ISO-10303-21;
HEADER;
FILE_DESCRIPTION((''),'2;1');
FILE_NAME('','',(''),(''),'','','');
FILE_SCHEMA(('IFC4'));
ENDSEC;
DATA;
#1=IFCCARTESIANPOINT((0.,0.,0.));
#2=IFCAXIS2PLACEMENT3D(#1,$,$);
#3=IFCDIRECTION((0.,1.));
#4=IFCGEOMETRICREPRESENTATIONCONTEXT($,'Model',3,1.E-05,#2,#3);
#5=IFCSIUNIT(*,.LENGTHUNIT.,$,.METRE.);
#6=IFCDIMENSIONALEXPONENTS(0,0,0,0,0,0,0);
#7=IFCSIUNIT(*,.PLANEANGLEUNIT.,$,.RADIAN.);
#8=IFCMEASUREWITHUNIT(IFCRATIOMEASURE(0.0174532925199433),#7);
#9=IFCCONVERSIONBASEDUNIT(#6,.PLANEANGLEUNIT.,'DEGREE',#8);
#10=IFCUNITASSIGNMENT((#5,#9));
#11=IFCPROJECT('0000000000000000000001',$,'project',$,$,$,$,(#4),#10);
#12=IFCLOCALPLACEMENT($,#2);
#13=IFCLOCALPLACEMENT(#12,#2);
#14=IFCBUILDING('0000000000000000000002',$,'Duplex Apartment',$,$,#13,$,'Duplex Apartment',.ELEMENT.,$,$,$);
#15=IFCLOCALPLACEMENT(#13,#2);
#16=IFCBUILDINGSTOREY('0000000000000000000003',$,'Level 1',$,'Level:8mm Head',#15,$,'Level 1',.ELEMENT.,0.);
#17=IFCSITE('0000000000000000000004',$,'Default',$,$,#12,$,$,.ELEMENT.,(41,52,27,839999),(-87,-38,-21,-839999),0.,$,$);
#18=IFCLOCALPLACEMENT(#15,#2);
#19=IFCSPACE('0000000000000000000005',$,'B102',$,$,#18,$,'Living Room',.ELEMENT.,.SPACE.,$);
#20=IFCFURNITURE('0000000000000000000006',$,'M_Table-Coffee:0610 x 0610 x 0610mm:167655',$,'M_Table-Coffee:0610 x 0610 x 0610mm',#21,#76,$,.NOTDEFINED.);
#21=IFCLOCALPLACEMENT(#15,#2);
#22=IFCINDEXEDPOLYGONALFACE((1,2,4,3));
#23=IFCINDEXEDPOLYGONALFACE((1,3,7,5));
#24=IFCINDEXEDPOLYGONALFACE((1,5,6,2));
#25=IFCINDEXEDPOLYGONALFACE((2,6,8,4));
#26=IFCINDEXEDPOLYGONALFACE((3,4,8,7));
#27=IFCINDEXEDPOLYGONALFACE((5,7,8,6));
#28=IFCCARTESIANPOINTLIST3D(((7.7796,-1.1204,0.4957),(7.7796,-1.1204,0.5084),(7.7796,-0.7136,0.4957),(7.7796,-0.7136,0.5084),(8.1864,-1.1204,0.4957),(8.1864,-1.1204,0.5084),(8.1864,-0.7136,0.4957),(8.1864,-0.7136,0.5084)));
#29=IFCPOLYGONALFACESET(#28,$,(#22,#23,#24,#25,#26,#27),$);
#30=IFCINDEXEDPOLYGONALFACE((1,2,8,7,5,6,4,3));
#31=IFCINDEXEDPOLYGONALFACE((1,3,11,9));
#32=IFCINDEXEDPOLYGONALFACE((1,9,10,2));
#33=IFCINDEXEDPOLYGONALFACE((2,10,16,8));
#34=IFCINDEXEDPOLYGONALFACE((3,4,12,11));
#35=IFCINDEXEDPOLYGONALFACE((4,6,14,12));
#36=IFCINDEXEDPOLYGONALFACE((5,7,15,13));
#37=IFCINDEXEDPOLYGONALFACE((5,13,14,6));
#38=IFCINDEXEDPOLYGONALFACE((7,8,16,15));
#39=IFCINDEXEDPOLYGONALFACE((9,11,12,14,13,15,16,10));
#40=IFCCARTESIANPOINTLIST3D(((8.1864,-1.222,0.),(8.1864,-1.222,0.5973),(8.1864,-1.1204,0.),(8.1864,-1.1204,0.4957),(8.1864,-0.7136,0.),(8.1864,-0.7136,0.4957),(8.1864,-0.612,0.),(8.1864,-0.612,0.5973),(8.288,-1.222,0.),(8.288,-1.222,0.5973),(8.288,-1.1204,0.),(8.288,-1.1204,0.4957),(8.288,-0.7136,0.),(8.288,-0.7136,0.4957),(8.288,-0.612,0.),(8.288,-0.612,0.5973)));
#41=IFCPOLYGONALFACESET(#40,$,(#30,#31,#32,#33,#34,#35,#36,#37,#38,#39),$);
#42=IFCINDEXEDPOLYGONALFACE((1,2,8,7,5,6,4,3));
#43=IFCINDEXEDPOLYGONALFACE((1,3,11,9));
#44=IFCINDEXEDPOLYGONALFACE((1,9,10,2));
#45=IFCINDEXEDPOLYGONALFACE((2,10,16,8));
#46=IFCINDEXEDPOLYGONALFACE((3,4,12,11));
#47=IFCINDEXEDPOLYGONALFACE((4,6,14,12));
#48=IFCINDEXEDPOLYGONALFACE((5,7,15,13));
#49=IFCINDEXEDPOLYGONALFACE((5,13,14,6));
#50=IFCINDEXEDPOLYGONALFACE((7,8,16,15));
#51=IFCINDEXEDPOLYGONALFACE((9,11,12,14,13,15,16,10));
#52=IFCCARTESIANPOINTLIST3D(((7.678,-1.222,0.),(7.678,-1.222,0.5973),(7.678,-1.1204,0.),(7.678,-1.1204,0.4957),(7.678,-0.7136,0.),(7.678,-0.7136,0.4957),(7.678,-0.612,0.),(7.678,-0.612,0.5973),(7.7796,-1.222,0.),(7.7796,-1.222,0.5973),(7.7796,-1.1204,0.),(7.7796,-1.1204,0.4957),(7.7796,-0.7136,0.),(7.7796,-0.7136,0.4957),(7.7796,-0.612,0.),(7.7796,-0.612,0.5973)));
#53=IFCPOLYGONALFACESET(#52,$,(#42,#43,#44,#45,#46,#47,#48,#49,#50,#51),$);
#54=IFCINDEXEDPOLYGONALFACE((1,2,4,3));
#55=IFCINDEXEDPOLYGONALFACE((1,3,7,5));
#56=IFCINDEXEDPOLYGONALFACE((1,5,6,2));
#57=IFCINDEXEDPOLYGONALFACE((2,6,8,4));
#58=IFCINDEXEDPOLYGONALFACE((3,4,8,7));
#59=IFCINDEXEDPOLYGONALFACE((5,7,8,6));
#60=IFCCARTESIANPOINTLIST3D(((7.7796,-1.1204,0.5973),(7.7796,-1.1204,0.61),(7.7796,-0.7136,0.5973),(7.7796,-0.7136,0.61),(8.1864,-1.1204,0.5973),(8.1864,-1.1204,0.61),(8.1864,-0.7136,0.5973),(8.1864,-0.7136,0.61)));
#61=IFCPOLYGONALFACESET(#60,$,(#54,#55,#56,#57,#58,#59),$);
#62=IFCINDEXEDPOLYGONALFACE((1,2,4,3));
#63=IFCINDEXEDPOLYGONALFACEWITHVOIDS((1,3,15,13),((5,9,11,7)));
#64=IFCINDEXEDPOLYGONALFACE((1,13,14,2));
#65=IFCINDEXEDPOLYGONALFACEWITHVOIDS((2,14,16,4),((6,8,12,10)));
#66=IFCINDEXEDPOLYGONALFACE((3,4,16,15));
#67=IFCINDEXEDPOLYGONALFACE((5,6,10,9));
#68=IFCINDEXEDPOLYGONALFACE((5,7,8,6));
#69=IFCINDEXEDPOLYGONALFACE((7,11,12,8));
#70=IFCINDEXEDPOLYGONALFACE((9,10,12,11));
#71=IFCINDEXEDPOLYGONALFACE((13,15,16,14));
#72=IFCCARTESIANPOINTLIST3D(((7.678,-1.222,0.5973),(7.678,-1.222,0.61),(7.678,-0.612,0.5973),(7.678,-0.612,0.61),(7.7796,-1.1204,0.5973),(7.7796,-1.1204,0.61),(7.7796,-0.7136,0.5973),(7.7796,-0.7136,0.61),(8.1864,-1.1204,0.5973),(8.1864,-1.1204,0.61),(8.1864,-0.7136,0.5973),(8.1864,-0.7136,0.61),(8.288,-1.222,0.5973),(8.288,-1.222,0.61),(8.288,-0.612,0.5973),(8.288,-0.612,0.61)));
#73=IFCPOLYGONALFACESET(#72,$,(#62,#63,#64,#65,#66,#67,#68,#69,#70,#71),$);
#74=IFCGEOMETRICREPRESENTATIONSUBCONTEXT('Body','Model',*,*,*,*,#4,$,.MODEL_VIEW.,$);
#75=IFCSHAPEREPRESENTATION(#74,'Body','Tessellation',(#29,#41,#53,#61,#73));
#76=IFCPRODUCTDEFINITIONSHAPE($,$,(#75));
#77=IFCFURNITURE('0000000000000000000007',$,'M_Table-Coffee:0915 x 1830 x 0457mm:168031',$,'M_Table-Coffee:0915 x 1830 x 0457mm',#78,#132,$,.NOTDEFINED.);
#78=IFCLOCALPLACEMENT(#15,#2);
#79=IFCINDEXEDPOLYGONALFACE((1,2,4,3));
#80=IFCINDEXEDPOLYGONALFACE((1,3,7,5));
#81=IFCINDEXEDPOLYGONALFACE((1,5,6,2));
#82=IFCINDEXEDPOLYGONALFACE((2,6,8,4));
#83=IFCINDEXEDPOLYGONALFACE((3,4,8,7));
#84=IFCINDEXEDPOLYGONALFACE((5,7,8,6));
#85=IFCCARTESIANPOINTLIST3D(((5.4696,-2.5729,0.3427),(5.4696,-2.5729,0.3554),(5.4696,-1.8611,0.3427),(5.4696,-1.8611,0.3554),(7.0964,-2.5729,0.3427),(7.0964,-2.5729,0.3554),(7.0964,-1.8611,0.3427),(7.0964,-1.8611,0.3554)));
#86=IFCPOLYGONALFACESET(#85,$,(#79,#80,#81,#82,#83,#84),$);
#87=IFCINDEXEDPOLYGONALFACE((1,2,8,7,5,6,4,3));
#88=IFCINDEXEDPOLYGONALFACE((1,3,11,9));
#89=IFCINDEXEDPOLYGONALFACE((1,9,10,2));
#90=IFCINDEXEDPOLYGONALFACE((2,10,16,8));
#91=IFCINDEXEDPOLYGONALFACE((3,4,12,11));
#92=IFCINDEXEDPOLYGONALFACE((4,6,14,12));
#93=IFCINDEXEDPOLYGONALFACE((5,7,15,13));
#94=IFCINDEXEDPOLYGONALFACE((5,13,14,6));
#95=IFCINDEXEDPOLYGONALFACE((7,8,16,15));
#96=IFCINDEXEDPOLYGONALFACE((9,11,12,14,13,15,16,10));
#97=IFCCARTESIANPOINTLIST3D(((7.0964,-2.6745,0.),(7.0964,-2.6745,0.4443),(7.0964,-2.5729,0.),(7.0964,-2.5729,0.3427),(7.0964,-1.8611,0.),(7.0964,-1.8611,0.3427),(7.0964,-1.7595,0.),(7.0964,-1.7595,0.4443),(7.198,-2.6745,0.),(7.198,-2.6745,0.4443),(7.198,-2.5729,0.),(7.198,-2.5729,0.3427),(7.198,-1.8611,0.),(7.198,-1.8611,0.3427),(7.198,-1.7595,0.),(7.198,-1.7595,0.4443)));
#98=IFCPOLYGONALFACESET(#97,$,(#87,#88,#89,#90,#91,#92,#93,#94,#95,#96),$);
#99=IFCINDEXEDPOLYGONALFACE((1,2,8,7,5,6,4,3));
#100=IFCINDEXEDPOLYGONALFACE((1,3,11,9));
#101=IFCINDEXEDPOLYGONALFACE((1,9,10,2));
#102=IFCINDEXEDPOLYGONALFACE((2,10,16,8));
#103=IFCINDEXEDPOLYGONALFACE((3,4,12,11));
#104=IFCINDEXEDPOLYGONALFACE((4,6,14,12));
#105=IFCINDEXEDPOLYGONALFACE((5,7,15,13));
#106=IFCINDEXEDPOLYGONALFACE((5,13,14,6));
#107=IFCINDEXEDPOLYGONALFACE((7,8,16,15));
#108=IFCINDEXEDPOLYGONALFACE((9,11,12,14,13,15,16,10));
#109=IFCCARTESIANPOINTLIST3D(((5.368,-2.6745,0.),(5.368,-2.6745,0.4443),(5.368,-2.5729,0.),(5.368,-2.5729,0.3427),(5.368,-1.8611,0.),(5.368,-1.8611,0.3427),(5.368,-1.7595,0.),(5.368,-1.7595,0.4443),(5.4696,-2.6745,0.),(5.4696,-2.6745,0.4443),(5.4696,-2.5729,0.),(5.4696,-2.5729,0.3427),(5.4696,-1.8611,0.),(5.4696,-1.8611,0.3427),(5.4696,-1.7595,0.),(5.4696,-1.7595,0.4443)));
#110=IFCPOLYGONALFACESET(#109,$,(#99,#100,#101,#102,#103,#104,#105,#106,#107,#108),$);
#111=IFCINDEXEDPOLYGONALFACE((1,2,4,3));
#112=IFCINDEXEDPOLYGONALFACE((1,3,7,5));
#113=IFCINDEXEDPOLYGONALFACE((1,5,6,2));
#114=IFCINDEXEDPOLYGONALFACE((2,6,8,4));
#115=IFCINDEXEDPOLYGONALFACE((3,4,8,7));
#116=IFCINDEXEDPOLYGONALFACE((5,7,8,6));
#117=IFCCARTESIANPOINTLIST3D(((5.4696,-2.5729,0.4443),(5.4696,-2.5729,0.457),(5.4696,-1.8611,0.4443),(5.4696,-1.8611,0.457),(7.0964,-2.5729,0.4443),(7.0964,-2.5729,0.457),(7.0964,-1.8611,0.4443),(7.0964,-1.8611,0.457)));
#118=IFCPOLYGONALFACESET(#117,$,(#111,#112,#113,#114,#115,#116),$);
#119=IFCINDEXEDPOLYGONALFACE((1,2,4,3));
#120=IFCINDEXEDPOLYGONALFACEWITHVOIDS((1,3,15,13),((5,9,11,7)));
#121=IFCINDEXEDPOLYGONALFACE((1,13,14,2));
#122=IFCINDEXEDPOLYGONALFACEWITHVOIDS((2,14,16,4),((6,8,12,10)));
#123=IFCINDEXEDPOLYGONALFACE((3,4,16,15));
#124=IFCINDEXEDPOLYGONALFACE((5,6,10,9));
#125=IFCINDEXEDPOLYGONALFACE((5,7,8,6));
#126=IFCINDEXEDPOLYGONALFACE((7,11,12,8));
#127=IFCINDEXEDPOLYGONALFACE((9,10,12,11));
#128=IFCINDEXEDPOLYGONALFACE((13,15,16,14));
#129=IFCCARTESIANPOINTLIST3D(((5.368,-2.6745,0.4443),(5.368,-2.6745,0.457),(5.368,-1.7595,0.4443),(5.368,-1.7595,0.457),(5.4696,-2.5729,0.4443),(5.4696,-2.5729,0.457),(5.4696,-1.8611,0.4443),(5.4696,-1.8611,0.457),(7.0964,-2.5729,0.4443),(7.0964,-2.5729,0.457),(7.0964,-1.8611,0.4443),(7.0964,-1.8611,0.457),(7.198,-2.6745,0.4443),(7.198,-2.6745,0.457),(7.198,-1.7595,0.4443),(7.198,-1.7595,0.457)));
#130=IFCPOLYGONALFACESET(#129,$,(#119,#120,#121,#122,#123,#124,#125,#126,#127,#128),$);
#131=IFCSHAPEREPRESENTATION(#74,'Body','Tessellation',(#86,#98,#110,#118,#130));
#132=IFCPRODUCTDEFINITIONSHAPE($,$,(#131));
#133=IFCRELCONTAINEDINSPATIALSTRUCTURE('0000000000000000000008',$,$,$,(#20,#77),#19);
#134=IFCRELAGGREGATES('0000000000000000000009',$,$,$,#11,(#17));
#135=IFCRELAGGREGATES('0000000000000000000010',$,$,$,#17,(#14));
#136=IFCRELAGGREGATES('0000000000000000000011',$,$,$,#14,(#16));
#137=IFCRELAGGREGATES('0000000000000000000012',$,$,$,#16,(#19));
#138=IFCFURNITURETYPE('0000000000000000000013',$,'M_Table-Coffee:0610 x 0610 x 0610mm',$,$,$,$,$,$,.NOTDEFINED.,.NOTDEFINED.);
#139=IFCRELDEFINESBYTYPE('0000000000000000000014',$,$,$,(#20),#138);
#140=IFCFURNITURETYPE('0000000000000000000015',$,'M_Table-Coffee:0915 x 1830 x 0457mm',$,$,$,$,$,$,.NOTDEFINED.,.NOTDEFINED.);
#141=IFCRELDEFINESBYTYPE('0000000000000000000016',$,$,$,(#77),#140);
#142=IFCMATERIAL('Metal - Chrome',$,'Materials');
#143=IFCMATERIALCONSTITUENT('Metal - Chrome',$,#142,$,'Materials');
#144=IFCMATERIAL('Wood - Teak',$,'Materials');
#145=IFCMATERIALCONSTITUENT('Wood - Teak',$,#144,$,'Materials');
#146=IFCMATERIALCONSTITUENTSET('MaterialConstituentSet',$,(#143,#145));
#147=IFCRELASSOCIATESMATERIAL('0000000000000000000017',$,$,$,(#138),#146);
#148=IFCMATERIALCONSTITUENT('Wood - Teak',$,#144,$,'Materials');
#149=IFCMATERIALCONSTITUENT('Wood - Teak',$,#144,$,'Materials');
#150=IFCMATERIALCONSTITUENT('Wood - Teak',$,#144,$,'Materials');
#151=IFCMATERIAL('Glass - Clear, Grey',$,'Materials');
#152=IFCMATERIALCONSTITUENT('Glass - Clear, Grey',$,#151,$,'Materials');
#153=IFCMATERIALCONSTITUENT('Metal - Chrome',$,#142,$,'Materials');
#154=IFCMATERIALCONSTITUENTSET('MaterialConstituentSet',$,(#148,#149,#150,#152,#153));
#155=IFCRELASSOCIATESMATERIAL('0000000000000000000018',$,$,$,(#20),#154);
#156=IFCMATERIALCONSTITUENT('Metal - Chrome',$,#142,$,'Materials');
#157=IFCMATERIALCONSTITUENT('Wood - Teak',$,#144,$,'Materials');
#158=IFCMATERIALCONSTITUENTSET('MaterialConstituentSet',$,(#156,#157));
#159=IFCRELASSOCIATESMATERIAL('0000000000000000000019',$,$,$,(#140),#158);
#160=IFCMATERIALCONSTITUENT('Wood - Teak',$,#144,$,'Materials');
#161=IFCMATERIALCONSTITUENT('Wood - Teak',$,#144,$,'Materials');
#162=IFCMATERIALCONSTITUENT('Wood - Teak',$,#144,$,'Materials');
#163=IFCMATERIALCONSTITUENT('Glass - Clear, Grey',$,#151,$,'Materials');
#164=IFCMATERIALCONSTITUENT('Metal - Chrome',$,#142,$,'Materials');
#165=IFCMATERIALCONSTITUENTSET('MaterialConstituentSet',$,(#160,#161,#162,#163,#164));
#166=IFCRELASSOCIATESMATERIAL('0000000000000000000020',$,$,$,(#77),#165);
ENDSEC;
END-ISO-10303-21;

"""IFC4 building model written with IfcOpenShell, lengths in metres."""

from ifc_helpers import new_model, entity, si_unit, converted_unit, direction, frame, origin, place, context, subcontext, project, spatial, indexed_curve, outline, extrude, source, transform, mapped, material, constituent, constituent_set, type_object, type_shapes, element, save


model = new_model("IFC4")

# Units and contexts
model_context = context("Model", 3, precision=1e-05, world=origin(), true_north=direction((0.0, 1.0)))
body_context = subcontext(model_context, "Body", "Model", "MODEL_VIEW")
ifc_project = project(units=[si_unit("LENGTHUNIT", "METRE"), converted_unit("PLANEANGLEUNIT", "DEGREE", entity("IfcRatioMeasure", 0.0174532925199433), si_unit("PLANEANGLEUNIT", "RADIAN"), dimensions=[0, 0, 0, 0, 0, 0, 0])], contexts=[model_context])

# Site, building, storey
site_placement = place(None, origin())
site = spatial("IfcSite", under=ifc_project, at=site_placement, Name="Default", CompositionType="ELEMENT", RefLatitude=(41, 52, 27, 839999), RefLongitude=(-87, -38, -21, -839999), RefElevation=0.0)
building_placement = place(site_placement, origin())
building = spatial("IfcBuilding", under=site, at=building_placement, Name="Duplex Apartment", LongName="Duplex Apartment", CompositionType="ELEMENT")
storey_placement = place(building_placement, origin())
storey = spatial("IfcBuildingStorey", under=building, at=storey_placement, Name="Level 1", ObjectType="Level:8mm Head", LongName="Level 1", CompositionType="ELEMENT", Elevation=0.0)

# Shared definitions
space_1_placement = place(storey_placement, origin())
space_1 = spatial("IfcSpace", under=storey, at=space_1_placement, Name="B102", LongName="Living Room", CompositionType="ELEMENT", PredefinedType="SPACE")

# Furniture
ifc_material_1 = material(Name="Wood - Teak", Category="Materials")
ifc_constituent_1 = constituent(ifc_material_1, Name="Wood - Teak", Category="Materials")
ifc_constituent_2 = constituent(ifc_material_1, Name="Wood - Teak", Category="Materials")
ifc_constituent_3 = constituent(ifc_material_1, Name="Wood - Teak", Category="Materials")
ifc_material_2 = material(Name="Glass - Clear, Grey", Category="Materials")
ifc_constituent_4 = constituent(ifc_material_2, Name="Glass - Clear, Grey", Category="Materials")
ifc_material_3 = material(Name="Metal - Chrome", Category="Materials")
ifc_constituent_5 = constituent(ifc_material_3, Name="Metal - Chrome", Category="Materials")
ifc_constituent_set_1 = constituent_set(constituents=[ifc_constituent_1, ifc_constituent_2, ifc_constituent_3, ifc_constituent_4, ifc_constituent_5], Name="MaterialConstituentSet")
ifc_constituent_6 = constituent(ifc_material_3, Name="Metal - Chrome", Category="Materials")
ifc_constituent_7 = constituent(ifc_material_1, Name="Wood - Teak", Category="Materials")
ifc_constituent_set_2 = constituent_set(constituents=[ifc_constituent_6, ifc_constituent_7], Name="MaterialConstituentSet")
furniture_type_1 = type_object("IfcFurnitureType", Name="M_Table-Coffee:0610 x 0610 x 0610mm", AssemblyPlace="NOTDEFINED", PredefinedType="NOTDEFINED", material=ifc_constituent_set_2)
shared_shape_1 = source(origin(), body_context, "Body", "SweptSolid", [
    extrude(outline(indexed_curve([(-0.2034, -0.2034), (0.2034, -0.2034), (0.2034, 0.2034), (-0.2034, 0.2034), (-0.2034, -0.2034)], self_intersect=False)), frame((0.0183, 0.0952, 0.4957), z_axis=(0.0, 0.0, 1.0), x_axis=(-1.0, 0.0, 0.0)), (0.0, 0.0, 1.0), 0.0127),
    extrude(outline(indexed_curve([(-0.2732, -0.305), (0.324, -0.305), (0.324, 0.305), (-0.2732, 0.305), (-0.2732, 0.2034), (0.2225, 0.2034), (0.2225, -0.2034), (-0.2732, -0.2034), (-0.2732, -0.305)], self_intersect=False)), frame((0.2217, 0.0952, 0.2732), z_axis=(1.0, 0.0, 0.0), x_axis=(0.0, 0.0, 1.0)), (0.0, 0.0, 1.0), 0.1016),
    extrude(outline(indexed_curve([(-0.305, -0.3241), (0.305, -0.3241), (0.305, 0.2733), (0.2034, 0.2733), (0.2034, -0.2224), (-0.2034, -0.2224), (-0.2034, 0.2733), (-0.305, 0.2733), (-0.305, -0.3241)], self_intersect=False)), frame((-0.2867, 0.0952, 0.2733), z_axis=(1.0, 0.0, 0.0), x_axis=(0.0, -1.0, 0.0)), (0.0, 0.0, 1.0), 0.1016),
    extrude(outline(indexed_curve([(-0.2034, -0.2034), (0.2034, -0.2034), (0.2034, 0.2034), (-0.2034, 0.2034), (-0.2034, -0.2034)], self_intersect=False)), frame((0.0183, 0.0952, 0.5973), z_axis=(0.0, 0.0, 1.0), x_axis=(-1.0, 0.0, 0.0)), (0.0, 0.0, 1.0), 0.0127),
    extrude(outline(indexed_curve([(-0.305, -0.305), (0.305, -0.305), (0.305, 0.305), (-0.305, 0.305), (-0.305, -0.305)], self_intersect=False), holes=[indexed_curve([(-0.2034, -0.2034), (-0.2034, 0.2034), (0.2034, 0.2034), (0.2034, -0.2034), (-0.2034, -0.2034)], self_intersect=False)]), frame((0.0183, 0.0952, 0.5973), z_axis=(0.0, 0.0, 1.0), x_axis=(-1.0, 0.0, 0.0)), (0.0, 0.0, 1.0), 0.0127),
])
type_shapes(furniture_type_1, [shared_shape_1])
furniture_1_placement = place(space_1_placement, frame((7.9647, -1.0122, 0.0)))
element("IfcFurniture", 1, at=furniture_1_placement, inside=space_1, type_object=furniture_type_1, material=ifc_constituent_set_1, Name="M_Table-Coffee:0610 x 0610 x 0610mm:167655", ObjectType="M_Table-Coffee:0610 x 0610 x 0610mm", PredefinedType="NOTDEFINED", context=body_context, shape_type="MappedRepresentation", body=[
    mapped(shared_shape_1, transform((0.0, 0.0, 0.0), scale=1.0)),
])
ifc_constituent_8 = constituent(ifc_material_1, Name="Wood - Teak", Category="Materials")
ifc_constituent_9 = constituent(ifc_material_1, Name="Wood - Teak", Category="Materials")
ifc_constituent_10 = constituent(ifc_material_1, Name="Wood - Teak", Category="Materials")
ifc_constituent_11 = constituent(ifc_material_2, Name="Glass - Clear, Grey", Category="Materials")
ifc_constituent_12 = constituent(ifc_material_3, Name="Metal - Chrome", Category="Materials")
ifc_constituent_set_3 = constituent_set(constituents=[ifc_constituent_8, ifc_constituent_9, ifc_constituent_10, ifc_constituent_11, ifc_constituent_12], Name="MaterialConstituentSet")
ifc_constituent_13 = constituent(ifc_material_3, Name="Metal - Chrome", Category="Materials")
ifc_constituent_14 = constituent(ifc_material_1, Name="Wood - Teak", Category="Materials")
ifc_constituent_set_4 = constituent_set(constituents=[ifc_constituent_13, ifc_constituent_14], Name="MaterialConstituentSet")
furniture_type_2 = type_object("IfcFurnitureType", Name="M_Table-Coffee:0915 x 1830 x 0457mm", AssemblyPlace="NOTDEFINED", PredefinedType="NOTDEFINED", material=ifc_constituent_set_4)
shared_shape_2 = source(origin(), body_context, "Body", "SweptSolid", [
    extrude(outline(indexed_curve([(-0.8134, -0.3559), (0.8134, -0.3559), (0.8134, 0.3559), (-0.8134, 0.3559), (-0.8134, -0.3559)], self_intersect=False)), frame((0.0183, 0.0952, 0.3427), z_axis=(0.0, 0.0, 1.0), x_axis=(-1.0, 0.0, 0.0)), (0.0, 0.0, 1.0), 0.0127),
    extrude(outline(indexed_curve([(-0.1967, -0.4575), (0.2475, -0.4575), (0.2475, 0.4575), (-0.1967, 0.4575), (-0.1967, 0.3559), (0.146, 0.3559), (0.146, -0.3559), (-0.1967, -0.3559), (-0.1967, -0.4575)], self_intersect=False)), frame((0.8317, 0.0952, 0.1967), z_axis=(1.0, 0.0, 0.0), x_axis=(0.0, 0.0, 1.0)), (0.0, 0.0, 1.0), 0.1016),
    extrude(outline(indexed_curve([(-0.4575, -0.2476), (0.4575, -0.2476), (0.4575, 0.1968), (0.3559, 0.1968), (0.3559, -0.1459), (-0.3559, -0.1459), (-0.3559, 0.1968), (-0.4575, 0.1968), (-0.4575, -0.2476)], self_intersect=False)), frame((-0.8967, 0.0952, 0.1968), z_axis=(1.0, 0.0, 0.0), x_axis=(0.0, -1.0, 0.0)), (0.0, 0.0, 1.0), 0.1016),
    extrude(outline(indexed_curve([(-0.8134, -0.3559), (0.8134, -0.3559), (0.8134, 0.3559), (-0.8134, 0.3559), (-0.8134, -0.3559)], self_intersect=False)), frame((0.0183, 0.0952, 0.4443), z_axis=(0.0, 0.0, 1.0), x_axis=(-1.0, 0.0, 0.0)), (0.0, 0.0, 1.0), 0.0127),
    extrude(outline(indexed_curve([(-0.915, -0.4575), (0.915, -0.4575), (0.915, 0.4575), (-0.915, 0.4575), (-0.915, -0.4575)], self_intersect=False), holes=[indexed_curve([(-0.8134, -0.3559), (-0.8134, 0.3559), (0.8134, 0.3559), (0.8134, -0.3559), (-0.8134, -0.3559)], self_intersect=False)]), frame((0.0183, 0.0952, 0.4443), z_axis=(0.0, 0.0, 1.0), x_axis=(-1.0, 0.0, 0.0)), (0.0, 0.0, 1.0), 0.0127),
])
type_shapes(furniture_type_2, [shared_shape_2])
furniture_2_placement = place(space_1_placement, frame((6.2647, -2.3122, 0.0)))
element("IfcFurniture", 2, at=furniture_2_placement, inside=space_1, type_object=furniture_type_2, material=ifc_constituent_set_3, Name="M_Table-Coffee:0915 x 1830 x 0457mm:168031", ObjectType="M_Table-Coffee:0915 x 1830 x 0457mm", PredefinedType="NOTDEFINED", context=body_context, shape_type="MappedRepresentation", body=[
    mapped(shared_shape_2, transform((0.0, 0.0, 0.0), scale=1.0)),
])

save(model, "model.ifc")
